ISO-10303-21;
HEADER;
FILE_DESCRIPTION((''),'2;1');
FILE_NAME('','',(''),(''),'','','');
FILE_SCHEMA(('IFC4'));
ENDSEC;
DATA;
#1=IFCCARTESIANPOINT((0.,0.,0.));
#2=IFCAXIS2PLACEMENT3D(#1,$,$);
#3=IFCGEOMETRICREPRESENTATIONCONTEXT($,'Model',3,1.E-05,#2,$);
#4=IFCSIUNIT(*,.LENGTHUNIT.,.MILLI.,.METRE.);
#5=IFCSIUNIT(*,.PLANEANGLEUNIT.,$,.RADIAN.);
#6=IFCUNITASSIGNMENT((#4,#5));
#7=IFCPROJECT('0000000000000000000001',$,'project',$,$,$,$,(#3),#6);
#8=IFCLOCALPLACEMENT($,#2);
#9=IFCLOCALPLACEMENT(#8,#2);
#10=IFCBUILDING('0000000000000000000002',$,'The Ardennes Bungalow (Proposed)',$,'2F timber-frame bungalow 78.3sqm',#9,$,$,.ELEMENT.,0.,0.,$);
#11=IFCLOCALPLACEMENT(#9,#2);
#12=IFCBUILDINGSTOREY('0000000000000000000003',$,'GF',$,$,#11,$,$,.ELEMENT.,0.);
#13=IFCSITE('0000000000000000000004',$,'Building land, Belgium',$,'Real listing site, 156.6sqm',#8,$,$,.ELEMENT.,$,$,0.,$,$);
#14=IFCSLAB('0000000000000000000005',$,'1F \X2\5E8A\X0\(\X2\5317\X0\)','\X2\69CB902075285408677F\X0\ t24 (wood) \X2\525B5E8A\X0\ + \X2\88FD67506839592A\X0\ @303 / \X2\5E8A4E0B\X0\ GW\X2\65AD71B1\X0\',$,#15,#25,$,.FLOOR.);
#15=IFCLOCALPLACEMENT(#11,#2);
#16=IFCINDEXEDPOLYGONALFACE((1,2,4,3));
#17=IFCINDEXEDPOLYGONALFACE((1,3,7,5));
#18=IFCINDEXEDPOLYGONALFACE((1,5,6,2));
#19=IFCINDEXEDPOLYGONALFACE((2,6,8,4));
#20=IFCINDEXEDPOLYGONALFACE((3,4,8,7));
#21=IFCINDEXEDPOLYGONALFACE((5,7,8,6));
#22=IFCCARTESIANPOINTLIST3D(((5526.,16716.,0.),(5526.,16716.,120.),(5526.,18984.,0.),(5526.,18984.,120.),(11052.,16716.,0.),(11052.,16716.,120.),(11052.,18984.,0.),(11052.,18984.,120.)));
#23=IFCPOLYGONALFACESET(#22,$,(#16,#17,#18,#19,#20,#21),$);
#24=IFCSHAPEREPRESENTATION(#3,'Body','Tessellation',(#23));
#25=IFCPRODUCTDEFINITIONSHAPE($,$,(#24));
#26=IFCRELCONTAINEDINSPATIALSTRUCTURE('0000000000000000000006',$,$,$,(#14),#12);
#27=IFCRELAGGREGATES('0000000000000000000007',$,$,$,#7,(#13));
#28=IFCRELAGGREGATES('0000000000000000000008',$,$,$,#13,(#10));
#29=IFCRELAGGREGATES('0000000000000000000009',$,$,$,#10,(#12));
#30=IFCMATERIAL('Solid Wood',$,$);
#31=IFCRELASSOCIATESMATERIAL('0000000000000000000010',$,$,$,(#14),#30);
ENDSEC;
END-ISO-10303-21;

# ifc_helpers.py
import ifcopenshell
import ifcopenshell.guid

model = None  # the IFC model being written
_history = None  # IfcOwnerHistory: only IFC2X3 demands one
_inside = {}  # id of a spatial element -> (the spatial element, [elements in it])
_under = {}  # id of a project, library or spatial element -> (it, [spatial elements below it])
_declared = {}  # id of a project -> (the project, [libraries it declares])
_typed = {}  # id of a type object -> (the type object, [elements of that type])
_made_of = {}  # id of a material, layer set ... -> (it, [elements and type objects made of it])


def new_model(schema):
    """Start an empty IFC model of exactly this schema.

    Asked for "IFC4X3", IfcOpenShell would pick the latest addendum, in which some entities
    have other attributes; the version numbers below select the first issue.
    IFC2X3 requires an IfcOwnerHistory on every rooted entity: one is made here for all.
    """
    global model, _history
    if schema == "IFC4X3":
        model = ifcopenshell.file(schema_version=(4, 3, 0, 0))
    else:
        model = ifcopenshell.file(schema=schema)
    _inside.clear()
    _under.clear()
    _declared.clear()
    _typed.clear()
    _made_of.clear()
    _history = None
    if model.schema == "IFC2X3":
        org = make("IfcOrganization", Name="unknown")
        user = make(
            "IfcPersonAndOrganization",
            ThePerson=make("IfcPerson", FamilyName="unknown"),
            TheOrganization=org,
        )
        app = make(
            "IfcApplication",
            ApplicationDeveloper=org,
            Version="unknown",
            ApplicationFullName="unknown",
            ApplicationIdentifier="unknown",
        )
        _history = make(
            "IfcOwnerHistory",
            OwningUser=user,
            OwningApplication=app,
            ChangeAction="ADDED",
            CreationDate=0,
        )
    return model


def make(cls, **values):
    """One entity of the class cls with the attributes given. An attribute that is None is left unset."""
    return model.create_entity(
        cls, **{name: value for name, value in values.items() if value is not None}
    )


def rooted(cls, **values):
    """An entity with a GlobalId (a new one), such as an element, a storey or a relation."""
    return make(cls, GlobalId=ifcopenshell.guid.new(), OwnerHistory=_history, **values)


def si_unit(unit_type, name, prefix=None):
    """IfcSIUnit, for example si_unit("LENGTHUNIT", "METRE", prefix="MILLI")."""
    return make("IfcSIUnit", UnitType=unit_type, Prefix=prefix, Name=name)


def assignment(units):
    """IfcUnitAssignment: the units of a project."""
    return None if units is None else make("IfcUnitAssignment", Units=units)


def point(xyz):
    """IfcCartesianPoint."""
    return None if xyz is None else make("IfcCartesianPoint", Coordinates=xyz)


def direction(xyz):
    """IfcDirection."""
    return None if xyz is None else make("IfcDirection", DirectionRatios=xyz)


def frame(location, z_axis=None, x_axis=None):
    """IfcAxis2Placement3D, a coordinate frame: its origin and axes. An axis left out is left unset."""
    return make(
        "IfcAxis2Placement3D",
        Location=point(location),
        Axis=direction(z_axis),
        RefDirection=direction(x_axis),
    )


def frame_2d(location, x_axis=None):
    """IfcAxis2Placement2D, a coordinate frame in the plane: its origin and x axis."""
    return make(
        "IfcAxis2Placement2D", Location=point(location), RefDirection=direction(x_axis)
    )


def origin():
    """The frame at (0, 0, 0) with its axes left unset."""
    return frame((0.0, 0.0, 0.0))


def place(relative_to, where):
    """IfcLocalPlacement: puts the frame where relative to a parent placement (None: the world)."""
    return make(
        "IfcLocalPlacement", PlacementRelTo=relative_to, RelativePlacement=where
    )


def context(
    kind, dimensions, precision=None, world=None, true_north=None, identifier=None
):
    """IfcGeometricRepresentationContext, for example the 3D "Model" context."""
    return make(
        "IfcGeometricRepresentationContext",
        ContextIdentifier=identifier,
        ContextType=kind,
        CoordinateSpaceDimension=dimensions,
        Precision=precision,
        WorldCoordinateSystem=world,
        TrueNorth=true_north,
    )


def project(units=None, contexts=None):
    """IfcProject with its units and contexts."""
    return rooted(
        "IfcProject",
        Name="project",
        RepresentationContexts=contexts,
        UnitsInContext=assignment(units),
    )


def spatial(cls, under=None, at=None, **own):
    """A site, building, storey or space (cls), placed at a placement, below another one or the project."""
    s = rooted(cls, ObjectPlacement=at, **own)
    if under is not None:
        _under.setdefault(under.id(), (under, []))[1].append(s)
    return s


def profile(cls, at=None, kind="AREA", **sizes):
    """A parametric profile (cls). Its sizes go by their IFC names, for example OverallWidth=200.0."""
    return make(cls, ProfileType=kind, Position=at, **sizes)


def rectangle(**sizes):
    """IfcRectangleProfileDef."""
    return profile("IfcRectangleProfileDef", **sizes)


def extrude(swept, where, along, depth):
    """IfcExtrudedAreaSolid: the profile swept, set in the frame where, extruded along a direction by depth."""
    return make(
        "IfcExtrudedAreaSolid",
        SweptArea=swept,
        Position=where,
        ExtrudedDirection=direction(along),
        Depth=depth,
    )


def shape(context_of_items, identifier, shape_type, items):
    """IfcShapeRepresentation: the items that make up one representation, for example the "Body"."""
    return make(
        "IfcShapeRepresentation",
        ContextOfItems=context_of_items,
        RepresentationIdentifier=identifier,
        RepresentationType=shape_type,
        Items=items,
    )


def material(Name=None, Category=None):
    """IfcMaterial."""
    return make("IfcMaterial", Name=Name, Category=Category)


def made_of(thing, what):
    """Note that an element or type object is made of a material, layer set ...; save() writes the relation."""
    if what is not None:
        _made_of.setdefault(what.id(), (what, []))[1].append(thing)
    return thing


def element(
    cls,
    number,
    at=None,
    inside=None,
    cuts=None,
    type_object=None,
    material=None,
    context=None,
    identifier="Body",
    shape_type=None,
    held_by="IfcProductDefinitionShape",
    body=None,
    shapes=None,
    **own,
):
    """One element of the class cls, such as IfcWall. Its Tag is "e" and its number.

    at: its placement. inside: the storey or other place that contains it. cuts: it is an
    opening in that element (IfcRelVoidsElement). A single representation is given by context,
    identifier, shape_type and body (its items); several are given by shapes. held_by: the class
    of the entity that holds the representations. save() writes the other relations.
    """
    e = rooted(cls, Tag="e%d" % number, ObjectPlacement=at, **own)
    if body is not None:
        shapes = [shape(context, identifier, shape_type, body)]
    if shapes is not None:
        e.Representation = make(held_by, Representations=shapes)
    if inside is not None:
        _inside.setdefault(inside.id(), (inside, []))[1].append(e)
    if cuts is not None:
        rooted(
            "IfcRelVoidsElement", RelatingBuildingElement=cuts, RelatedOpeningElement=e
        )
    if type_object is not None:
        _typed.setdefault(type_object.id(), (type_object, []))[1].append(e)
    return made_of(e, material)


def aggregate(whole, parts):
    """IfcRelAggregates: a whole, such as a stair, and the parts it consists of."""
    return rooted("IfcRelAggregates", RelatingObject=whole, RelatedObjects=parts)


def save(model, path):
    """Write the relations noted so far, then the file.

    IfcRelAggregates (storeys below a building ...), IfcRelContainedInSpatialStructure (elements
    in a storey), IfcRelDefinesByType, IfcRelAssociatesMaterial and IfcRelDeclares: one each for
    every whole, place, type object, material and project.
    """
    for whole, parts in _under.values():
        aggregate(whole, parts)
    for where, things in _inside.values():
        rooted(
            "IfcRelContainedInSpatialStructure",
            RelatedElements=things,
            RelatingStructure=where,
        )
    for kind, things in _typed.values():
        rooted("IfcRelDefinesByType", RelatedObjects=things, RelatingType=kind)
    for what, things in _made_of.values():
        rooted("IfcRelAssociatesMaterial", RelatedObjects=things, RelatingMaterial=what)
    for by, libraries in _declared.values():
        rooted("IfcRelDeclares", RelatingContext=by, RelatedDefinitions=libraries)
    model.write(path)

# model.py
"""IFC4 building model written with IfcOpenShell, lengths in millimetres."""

from ifc_helpers import new_model, si_unit, frame, frame_2d, origin, place, context, project, spatial, rectangle, extrude, material, element, save


model = new_model("IFC4")

# Units and contexts
model_context = context("Model", 3, precision=1e-05, world=origin())
ifc_project = project(units=[si_unit("LENGTHUNIT", "METRE", prefix="MILLI"), si_unit("PLANEANGLEUNIT", "RADIAN")], contexts=[model_context])

# Site, building, storey
site_placement = place(None, origin())
site = spatial("IfcSite", under=ifc_project, at=site_placement, Name="Building land, Belgium", ObjectType="Real listing site, 156.6sqm", CompositionType="ELEMENT", RefElevation=0.0)
building_placement = place(site_placement, origin())
building = spatial("IfcBuilding", under=site, at=building_placement, Name="The Ardennes Bungalow (Proposed)", ObjectType="2F timber-frame bungalow 78.3sqm", CompositionType="ELEMENT", ElevationOfRefHeight=0.0, ElevationOfTerrain=0.0)
storey_placement = place(building_placement, origin())
storey = spatial("IfcBuildingStorey", under=building, at=storey_placement, Name="GF", CompositionType="ELEMENT", Elevation=0.0)

# Slab
ifc_material_1 = material(Name="Solid Wood")
slab_1_placement = place(storey_placement, frame((2763.0, 8358.0, 0.0)))
element("IfcSlab", 1, at=slab_1_placement, inside=storey, material=ifc_material_1, Name="1F 床(北)", Description="構造用合板 t24 (wood) 剛床 + 製材根太 @303 / 床下 GW断熱", PredefinedType="FLOOR", context=model_context, shape_type="SweptSolid", body=[
    extrude(rectangle(XDim=5526.0, YDim=2268.0, at=frame_2d((2763.0, 1134.0))), frame((2763.0, 8358.0, 0.0)), (0.0, 0.0, 1.0), 120.0),
])

save(model, "model.ifc")
